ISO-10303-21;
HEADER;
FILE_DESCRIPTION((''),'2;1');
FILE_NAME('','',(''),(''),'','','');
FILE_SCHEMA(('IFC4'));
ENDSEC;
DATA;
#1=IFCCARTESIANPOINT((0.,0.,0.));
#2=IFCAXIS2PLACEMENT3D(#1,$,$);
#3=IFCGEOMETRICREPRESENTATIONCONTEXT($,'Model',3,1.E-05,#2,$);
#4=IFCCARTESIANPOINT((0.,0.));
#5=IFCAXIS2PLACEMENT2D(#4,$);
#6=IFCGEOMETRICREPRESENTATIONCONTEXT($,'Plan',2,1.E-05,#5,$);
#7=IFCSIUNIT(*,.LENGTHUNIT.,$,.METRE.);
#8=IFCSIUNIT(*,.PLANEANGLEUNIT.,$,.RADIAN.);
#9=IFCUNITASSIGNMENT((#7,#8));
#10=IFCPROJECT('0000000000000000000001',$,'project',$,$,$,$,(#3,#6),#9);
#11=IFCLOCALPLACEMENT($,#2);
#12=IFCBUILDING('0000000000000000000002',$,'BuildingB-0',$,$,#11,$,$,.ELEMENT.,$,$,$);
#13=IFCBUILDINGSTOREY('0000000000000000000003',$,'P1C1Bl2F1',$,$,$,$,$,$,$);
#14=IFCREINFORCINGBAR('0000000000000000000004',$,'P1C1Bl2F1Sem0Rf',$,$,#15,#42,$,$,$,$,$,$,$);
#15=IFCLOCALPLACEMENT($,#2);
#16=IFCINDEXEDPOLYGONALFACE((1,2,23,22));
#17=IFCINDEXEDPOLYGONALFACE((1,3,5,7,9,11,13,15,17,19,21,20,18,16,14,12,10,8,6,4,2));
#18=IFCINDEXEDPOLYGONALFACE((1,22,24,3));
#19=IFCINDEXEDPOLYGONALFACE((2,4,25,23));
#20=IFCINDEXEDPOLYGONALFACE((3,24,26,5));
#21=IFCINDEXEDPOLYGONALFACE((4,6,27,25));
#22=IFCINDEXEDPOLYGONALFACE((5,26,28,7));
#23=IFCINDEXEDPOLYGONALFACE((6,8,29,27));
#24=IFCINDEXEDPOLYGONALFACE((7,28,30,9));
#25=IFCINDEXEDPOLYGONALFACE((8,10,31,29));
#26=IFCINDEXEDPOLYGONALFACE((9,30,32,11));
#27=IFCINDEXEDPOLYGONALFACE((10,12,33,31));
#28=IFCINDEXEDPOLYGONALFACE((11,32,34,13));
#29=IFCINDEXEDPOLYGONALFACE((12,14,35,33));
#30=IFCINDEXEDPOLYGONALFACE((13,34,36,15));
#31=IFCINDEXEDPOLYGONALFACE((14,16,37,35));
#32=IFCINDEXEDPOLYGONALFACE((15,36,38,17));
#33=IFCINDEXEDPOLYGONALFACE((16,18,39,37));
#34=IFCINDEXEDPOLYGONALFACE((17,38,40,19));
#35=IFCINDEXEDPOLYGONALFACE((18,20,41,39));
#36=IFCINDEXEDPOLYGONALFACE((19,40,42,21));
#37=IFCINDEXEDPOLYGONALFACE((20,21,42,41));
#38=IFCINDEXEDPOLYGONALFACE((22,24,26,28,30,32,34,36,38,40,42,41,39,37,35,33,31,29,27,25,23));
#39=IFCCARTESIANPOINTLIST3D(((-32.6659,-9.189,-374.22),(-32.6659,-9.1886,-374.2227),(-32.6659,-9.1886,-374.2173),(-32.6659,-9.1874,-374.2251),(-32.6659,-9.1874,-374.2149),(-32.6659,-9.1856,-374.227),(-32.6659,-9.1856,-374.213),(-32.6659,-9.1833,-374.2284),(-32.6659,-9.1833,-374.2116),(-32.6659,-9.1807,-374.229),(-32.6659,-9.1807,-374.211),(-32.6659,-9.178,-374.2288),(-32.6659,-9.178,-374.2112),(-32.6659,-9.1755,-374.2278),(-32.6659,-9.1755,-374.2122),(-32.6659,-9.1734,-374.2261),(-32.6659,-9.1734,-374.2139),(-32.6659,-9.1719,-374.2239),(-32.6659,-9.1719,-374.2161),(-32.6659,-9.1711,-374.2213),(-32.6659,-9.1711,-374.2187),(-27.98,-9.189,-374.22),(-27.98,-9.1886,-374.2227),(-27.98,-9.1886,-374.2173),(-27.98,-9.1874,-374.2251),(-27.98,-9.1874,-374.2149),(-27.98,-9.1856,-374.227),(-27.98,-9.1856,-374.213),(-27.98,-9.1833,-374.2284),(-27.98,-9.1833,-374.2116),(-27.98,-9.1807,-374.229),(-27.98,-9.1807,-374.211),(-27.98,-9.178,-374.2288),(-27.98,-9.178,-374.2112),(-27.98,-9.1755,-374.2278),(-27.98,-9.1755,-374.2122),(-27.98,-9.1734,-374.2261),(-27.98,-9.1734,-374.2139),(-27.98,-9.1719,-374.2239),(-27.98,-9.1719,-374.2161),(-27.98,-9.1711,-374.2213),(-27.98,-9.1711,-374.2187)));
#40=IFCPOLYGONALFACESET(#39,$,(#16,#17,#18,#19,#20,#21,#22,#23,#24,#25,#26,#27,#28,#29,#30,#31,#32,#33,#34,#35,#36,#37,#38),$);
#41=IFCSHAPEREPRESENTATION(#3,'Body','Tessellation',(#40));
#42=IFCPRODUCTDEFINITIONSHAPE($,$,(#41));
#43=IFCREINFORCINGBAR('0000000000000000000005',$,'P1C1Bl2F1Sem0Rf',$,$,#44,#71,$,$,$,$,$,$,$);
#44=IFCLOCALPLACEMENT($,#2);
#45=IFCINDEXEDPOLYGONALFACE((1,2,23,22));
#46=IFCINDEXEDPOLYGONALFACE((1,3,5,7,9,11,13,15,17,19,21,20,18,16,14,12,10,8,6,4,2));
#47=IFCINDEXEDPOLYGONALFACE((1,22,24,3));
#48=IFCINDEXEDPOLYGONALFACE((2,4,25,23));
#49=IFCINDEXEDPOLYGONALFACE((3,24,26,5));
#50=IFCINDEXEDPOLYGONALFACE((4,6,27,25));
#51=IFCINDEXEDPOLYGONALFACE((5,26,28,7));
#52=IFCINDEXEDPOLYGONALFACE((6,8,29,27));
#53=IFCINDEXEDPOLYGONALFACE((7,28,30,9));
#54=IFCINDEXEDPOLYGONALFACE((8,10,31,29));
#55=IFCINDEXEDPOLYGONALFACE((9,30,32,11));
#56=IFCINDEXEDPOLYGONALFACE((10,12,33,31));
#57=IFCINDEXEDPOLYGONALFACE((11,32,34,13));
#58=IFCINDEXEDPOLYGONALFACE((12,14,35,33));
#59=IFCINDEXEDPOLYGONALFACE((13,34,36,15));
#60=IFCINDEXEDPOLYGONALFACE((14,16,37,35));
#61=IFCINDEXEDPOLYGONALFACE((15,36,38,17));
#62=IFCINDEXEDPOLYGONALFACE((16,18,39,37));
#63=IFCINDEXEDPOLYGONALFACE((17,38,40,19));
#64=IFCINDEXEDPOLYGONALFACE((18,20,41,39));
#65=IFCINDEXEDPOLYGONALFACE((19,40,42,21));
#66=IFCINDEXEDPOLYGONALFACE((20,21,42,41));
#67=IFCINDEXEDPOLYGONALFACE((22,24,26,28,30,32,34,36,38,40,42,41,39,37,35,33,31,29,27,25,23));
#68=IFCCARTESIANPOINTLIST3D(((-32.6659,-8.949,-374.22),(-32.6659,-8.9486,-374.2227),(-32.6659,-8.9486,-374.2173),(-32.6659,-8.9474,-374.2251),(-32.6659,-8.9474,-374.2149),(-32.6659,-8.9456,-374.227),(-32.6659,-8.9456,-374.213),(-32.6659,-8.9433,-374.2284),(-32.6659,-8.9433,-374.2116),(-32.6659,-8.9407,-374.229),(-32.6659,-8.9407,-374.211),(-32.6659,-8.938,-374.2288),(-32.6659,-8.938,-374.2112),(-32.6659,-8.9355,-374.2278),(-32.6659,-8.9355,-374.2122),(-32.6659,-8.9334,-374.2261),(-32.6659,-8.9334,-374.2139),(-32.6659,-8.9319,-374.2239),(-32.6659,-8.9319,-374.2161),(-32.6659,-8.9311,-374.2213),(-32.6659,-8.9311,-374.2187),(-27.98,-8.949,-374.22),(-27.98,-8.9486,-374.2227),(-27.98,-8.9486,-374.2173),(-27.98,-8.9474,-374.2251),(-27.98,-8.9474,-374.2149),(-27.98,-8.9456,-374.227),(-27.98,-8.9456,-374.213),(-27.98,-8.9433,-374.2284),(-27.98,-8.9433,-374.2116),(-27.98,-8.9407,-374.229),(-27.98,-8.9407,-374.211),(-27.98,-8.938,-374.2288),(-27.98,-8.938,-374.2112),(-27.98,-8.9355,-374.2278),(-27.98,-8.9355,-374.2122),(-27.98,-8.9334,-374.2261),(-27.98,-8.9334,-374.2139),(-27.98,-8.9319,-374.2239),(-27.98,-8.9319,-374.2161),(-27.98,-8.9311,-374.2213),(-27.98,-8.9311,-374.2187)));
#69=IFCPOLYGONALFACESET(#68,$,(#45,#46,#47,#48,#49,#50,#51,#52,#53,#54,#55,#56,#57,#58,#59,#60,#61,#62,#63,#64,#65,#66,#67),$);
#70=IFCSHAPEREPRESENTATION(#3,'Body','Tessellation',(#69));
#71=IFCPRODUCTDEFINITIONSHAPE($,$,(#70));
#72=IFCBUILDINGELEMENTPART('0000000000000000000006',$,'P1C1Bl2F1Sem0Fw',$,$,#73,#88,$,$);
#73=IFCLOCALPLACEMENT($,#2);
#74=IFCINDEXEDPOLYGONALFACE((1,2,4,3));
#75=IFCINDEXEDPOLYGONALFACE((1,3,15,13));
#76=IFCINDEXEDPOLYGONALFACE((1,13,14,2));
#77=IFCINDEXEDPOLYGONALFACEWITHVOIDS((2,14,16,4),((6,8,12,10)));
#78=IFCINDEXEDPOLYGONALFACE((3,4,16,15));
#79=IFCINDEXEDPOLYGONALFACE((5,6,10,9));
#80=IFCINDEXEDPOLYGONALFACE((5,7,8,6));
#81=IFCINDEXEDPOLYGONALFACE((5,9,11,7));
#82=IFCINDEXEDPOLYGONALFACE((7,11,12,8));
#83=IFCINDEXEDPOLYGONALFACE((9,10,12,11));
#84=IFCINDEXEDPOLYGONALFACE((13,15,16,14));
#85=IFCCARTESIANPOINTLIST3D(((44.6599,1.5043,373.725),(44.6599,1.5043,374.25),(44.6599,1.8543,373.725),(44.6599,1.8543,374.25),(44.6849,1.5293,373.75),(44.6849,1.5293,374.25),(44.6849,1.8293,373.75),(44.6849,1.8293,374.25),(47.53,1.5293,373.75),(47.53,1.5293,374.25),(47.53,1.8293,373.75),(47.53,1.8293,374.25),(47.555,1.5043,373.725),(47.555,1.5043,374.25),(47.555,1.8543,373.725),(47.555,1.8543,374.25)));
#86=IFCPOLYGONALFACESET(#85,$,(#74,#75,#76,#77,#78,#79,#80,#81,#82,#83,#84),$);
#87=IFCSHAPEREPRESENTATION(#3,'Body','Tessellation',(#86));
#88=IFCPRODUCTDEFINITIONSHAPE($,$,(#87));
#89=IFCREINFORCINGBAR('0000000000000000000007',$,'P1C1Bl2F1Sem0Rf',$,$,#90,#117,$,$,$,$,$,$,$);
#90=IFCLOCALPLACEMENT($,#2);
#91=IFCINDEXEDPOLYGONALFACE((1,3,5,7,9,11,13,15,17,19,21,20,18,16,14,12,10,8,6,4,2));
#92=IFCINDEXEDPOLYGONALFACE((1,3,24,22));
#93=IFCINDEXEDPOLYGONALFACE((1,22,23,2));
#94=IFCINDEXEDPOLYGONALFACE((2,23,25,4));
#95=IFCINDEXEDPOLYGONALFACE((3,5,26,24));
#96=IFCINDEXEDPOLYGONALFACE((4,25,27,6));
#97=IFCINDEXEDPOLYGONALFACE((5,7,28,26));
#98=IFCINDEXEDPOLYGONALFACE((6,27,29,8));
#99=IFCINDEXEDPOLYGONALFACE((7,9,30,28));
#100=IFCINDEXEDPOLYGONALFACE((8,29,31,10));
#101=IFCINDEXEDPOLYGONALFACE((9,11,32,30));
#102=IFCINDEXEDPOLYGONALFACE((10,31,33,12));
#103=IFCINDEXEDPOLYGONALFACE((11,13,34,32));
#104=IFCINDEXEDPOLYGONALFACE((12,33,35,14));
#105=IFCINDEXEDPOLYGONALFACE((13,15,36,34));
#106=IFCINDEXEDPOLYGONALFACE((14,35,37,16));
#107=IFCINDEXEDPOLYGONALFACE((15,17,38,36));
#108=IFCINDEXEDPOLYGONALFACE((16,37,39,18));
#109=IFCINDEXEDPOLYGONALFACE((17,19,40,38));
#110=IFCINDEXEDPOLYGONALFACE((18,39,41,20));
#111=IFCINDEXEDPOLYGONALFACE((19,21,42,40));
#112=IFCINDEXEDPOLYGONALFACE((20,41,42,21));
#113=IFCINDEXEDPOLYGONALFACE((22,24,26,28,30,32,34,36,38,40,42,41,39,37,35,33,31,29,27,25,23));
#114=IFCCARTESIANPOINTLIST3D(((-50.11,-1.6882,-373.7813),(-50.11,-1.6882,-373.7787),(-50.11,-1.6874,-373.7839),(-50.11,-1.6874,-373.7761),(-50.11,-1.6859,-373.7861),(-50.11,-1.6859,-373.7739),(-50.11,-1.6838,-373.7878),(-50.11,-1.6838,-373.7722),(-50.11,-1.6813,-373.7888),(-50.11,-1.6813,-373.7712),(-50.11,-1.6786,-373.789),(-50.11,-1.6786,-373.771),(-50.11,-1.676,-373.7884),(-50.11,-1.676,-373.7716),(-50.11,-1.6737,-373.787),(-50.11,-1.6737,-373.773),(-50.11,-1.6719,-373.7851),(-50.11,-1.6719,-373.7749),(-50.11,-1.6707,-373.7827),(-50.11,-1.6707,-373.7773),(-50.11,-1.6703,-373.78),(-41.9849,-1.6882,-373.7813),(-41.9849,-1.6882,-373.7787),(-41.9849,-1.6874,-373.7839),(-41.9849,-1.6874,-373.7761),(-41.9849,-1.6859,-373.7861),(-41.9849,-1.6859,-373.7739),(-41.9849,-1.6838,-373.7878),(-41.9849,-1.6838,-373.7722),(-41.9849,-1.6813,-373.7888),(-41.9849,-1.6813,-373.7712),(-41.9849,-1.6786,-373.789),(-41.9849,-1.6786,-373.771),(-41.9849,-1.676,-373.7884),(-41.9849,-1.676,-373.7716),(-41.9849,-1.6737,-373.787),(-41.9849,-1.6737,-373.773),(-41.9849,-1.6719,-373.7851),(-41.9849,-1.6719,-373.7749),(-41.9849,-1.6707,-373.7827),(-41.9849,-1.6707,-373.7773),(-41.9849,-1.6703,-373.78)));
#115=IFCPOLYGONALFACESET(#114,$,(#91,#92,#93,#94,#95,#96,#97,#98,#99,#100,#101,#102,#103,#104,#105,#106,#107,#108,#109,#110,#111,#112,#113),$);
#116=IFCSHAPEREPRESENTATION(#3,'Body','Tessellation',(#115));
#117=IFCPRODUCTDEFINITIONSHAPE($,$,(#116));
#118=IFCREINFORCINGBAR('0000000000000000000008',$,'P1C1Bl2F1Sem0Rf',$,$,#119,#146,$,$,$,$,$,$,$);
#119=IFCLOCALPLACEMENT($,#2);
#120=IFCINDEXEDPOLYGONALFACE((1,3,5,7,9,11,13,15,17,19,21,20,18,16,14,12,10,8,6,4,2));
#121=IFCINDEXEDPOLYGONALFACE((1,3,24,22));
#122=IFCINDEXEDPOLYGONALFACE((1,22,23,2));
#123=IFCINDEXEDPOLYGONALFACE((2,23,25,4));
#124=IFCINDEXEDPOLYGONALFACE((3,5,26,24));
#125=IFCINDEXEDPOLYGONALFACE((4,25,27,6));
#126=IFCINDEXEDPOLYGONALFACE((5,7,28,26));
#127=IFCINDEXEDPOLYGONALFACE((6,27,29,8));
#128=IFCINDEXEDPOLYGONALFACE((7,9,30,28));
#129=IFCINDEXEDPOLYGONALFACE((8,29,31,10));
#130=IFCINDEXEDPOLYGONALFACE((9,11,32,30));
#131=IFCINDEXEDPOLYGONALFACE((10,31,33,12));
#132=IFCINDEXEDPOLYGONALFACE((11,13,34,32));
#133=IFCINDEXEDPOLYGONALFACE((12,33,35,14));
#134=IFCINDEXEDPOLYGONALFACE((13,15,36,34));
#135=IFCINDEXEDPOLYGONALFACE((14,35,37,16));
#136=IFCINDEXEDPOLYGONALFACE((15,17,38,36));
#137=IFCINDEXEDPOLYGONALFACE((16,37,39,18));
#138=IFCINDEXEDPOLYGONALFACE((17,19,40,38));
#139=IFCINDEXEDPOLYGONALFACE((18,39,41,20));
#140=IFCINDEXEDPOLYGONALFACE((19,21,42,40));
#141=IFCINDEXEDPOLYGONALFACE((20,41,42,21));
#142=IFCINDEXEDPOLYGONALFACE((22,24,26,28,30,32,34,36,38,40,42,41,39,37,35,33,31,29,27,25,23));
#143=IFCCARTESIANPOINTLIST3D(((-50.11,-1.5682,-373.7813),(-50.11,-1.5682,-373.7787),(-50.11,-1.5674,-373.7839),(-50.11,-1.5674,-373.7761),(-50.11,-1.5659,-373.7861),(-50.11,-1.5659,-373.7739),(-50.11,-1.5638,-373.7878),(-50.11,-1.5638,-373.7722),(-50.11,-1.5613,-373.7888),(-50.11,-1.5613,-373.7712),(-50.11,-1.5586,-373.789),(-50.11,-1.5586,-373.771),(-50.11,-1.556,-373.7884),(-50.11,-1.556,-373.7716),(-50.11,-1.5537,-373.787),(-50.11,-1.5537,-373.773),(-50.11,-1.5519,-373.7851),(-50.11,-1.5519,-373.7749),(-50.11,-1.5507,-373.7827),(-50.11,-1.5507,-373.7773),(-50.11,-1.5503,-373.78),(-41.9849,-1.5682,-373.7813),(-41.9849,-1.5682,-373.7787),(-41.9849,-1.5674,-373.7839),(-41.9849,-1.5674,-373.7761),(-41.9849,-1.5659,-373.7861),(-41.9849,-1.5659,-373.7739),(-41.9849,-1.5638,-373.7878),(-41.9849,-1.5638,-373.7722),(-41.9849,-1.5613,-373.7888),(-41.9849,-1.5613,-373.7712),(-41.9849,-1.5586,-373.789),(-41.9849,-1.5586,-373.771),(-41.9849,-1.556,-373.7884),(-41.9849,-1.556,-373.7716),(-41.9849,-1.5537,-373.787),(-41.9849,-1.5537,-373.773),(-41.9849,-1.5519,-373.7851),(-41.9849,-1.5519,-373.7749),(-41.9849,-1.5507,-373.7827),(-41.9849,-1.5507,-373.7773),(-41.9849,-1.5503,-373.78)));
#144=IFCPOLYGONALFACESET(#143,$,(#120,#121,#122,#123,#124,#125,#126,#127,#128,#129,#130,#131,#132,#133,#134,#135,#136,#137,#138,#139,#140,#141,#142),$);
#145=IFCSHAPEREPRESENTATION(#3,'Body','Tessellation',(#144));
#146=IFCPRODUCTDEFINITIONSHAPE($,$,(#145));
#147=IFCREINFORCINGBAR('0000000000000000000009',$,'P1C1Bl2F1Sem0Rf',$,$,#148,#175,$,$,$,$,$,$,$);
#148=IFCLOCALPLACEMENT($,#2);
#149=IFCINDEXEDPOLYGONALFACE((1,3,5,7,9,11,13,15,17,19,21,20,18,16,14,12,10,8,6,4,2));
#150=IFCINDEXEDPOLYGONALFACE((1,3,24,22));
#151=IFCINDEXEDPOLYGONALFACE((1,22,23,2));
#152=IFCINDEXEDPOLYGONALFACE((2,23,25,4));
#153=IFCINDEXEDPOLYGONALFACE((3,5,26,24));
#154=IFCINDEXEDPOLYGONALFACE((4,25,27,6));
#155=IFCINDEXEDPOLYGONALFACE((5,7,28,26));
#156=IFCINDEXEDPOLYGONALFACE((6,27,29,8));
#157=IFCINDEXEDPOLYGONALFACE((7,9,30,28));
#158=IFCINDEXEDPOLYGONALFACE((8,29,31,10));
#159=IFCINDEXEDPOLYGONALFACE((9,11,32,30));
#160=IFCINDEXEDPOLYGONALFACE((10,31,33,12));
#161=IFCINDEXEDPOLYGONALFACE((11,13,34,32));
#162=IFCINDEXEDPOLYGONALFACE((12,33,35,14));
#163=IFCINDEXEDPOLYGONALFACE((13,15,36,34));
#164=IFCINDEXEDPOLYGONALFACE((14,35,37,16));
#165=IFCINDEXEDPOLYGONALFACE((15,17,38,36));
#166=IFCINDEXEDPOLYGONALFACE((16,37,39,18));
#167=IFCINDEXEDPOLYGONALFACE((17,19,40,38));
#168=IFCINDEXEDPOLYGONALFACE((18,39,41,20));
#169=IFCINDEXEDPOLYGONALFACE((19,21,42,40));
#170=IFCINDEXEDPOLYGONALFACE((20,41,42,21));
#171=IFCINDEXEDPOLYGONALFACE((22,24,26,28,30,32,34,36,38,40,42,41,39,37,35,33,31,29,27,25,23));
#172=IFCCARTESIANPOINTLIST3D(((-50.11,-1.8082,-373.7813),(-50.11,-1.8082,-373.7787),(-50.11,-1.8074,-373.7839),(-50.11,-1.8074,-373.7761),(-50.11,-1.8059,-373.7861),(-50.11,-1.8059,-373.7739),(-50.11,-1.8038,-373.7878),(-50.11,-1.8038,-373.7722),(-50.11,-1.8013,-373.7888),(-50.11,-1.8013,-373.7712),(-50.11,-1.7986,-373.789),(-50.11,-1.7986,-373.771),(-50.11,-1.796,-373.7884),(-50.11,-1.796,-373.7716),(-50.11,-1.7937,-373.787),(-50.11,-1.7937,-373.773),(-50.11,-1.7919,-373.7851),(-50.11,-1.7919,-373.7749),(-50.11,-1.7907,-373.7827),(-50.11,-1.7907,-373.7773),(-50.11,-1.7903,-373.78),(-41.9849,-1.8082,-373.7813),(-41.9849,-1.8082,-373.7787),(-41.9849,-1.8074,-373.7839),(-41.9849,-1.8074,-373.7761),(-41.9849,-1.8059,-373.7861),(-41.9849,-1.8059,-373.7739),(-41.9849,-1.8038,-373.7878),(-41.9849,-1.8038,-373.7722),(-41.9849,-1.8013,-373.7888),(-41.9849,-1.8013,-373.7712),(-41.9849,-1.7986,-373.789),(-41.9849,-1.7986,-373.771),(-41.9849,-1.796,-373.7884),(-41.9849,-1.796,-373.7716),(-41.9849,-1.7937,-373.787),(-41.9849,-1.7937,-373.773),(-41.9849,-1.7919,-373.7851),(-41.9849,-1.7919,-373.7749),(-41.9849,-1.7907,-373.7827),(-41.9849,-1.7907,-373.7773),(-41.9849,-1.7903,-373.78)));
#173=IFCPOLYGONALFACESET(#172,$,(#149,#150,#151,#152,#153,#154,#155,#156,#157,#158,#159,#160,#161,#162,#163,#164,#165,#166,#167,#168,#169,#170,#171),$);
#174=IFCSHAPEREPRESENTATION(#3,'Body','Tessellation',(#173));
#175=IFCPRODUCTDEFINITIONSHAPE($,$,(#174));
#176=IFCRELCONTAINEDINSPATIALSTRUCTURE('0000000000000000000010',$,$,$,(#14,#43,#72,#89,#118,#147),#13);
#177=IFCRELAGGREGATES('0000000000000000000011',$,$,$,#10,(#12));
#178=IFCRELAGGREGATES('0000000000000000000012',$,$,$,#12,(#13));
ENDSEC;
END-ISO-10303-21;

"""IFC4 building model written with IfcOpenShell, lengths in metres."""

from ifc_helpers import new_model, entity, si_unit, origin, origin_2d, place, context, project, spatial, polyline, outline, extrude, element, save


model = new_model("IFC4")

# Units and contexts
model_context = context("Model", 3, precision=1e-05, world=origin())
plan_context = context("Plan", 2, precision=1e-05, world=origin_2d())
ifc_project = project(units=[si_unit("LENGTHUNIT", "METRE"), si_unit("PLANEANGLEUNIT", "RADIAN")], contexts=[model_context, plan_context])

# Building, storey
building_placement = place(None, origin())
building = spatial("IfcBuilding", under=ifc_project, at=building_placement, Name="BuildingB-0", CompositionType="ELEMENT")
storey = spatial("IfcBuildingStorey", under=building, Name="P1C1Bl2F1")

# Reinforcing bars
element("IfcReinforcingBar", 1, inside=storey, Name="P1C1Bl2F1Sem0Rf", context=model_context, shape_type="SweptSolid", body=[
    entity("IfcSurfaceCurveSweptAreaSolid", entity("IfcCircleProfileDef", "AREA", None, None, 0.009), None, entity("IfcPolyline", [entity("IfcCartesianPoint", [32.6659, 9.18, 374.22]), entity("IfcCartesianPoint", [27.98, 9.18, 374.22])]), None, None, entity("IfcPlane", entity("IfcAxis2Placement3D", entity("IfcCartesianPoint", [32.6659, 9.18, 374.22]), entity("IfcDirection", [0.0, 0.0, 1.0]), entity("IfcDirection", [1.0, 0.0, 0.0])))),
])
element("IfcReinforcingBar", 2, inside=storey, Name="P1C1Bl2F1Sem0Rf", context=model_context, shape_type="SweptSolid", body=[
    entity("IfcSurfaceCurveSweptAreaSolid", entity("IfcCircleProfileDef", "AREA", None, None, 0.009), None, entity("IfcPolyline", [entity("IfcCartesianPoint", [32.6659, 8.94, 374.22]), entity("IfcCartesianPoint", [27.98, 8.94, 374.22])]), None, None, entity("IfcPlane", entity("IfcAxis2Placement3D", entity("IfcCartesianPoint", [32.6659, 8.94, 374.22]), entity("IfcDirection", [0.0, 0.0, 1.0]), entity("IfcDirection", [1.0, 0.0, 0.0])))),
])

# Building element part, opening
building_element_part_1 = element("IfcBuildingElementPart", 3, inside=storey, Name="P1C1Bl2F1Sem0Fw", context=model_context, shape_type="SweptSolid", body=[
    extrude(outline(polyline([(44.6599, 1.5043, 373.725), (44.6599, 1.8543, 373.725), (47.555, 1.8543, 373.725), (47.555, 1.5043, 373.725), (44.6599, 1.5043, 373.725)])), None, (0.0, 0.0, 1.0), 0.525),
])
element("IfcOpeningElement", 4, inside=storey, cuts=building_element_part_1, context=model_context, shape_type="SweptSolid", body=[
    extrude(outline(polyline([(44.6849, 1.5293, 373.75), (44.6849, 1.8293, 373.75), (47.53, 1.8293, 373.75), (47.53, 1.5293, 373.75), (44.6849, 1.5293, 373.75)])), None, (0.0, 0.0, 1.0), 0.5),
])

# Reinforcing bars
element("IfcReinforcingBar", 5, inside=storey, Name="P1C1Bl2F1Sem0Rf", context=model_context, shape_type="SweptSolid", body=[
    entity("IfcSurfaceCurveSweptAreaSolid", entity("IfcCircleProfileDef", "AREA", None, None, 0.009), None, entity("IfcPolyline", [entity("IfcCartesianPoint", [41.9849, 1.6793, 373.78]), entity("IfcCartesianPoint", [50.11, 1.6793, 373.78])]), None, None, entity("IfcPlane", entity("IfcAxis2Placement3D", entity("IfcCartesianPoint", [41.9849, 1.6793, 373.78]), entity("IfcDirection", [0.0, 0.0, 1.0]), entity("IfcDirection", [1.0, 0.0, 0.0])))),
])
element("IfcReinforcingBar", 6, inside=storey, Name="P1C1Bl2F1Sem0Rf", context=model_context, shape_type="SweptSolid", body=[
    entity("IfcSurfaceCurveSweptAreaSolid", entity("IfcCircleProfileDef", "AREA", None, None, 0.009), None, entity("IfcPolyline", [entity("IfcCartesianPoint", [41.9849, 1.5593, 373.78]), entity("IfcCartesianPoint", [50.11, 1.5593, 373.78])]), None, None, entity("IfcPlane", entity("IfcAxis2Placement3D", entity("IfcCartesianPoint", [41.9849, 1.5593, 373.78]), entity("IfcDirection", [0.0, 0.0, 1.0]), entity("IfcDirection", [1.0, 0.0, 0.0])))),
])
element("IfcReinforcingBar", 7, inside=storey, Name="P1C1Bl2F1Sem0Rf", context=model_context, shape_type="SweptSolid", body=[
    entity("IfcSurfaceCurveSweptAreaSolid", entity("IfcCircleProfileDef", "AREA", None, None, 0.009), None, entity("IfcPolyline", [entity("IfcCartesianPoint", [41.9849, 1.7993, 373.78]), entity("IfcCartesianPoint", [50.11, 1.7993, 373.78])]), None, None, entity("IfcPlane", entity("IfcAxis2Placement3D", entity("IfcCartesianPoint", [41.9849, 1.7993, 373.78]), entity("IfcDirection", [0.0, 0.0, 1.0]), entity("IfcDirection", [1.0, 0.0, 0.0])))),
])

save(model, "model.ifc")
